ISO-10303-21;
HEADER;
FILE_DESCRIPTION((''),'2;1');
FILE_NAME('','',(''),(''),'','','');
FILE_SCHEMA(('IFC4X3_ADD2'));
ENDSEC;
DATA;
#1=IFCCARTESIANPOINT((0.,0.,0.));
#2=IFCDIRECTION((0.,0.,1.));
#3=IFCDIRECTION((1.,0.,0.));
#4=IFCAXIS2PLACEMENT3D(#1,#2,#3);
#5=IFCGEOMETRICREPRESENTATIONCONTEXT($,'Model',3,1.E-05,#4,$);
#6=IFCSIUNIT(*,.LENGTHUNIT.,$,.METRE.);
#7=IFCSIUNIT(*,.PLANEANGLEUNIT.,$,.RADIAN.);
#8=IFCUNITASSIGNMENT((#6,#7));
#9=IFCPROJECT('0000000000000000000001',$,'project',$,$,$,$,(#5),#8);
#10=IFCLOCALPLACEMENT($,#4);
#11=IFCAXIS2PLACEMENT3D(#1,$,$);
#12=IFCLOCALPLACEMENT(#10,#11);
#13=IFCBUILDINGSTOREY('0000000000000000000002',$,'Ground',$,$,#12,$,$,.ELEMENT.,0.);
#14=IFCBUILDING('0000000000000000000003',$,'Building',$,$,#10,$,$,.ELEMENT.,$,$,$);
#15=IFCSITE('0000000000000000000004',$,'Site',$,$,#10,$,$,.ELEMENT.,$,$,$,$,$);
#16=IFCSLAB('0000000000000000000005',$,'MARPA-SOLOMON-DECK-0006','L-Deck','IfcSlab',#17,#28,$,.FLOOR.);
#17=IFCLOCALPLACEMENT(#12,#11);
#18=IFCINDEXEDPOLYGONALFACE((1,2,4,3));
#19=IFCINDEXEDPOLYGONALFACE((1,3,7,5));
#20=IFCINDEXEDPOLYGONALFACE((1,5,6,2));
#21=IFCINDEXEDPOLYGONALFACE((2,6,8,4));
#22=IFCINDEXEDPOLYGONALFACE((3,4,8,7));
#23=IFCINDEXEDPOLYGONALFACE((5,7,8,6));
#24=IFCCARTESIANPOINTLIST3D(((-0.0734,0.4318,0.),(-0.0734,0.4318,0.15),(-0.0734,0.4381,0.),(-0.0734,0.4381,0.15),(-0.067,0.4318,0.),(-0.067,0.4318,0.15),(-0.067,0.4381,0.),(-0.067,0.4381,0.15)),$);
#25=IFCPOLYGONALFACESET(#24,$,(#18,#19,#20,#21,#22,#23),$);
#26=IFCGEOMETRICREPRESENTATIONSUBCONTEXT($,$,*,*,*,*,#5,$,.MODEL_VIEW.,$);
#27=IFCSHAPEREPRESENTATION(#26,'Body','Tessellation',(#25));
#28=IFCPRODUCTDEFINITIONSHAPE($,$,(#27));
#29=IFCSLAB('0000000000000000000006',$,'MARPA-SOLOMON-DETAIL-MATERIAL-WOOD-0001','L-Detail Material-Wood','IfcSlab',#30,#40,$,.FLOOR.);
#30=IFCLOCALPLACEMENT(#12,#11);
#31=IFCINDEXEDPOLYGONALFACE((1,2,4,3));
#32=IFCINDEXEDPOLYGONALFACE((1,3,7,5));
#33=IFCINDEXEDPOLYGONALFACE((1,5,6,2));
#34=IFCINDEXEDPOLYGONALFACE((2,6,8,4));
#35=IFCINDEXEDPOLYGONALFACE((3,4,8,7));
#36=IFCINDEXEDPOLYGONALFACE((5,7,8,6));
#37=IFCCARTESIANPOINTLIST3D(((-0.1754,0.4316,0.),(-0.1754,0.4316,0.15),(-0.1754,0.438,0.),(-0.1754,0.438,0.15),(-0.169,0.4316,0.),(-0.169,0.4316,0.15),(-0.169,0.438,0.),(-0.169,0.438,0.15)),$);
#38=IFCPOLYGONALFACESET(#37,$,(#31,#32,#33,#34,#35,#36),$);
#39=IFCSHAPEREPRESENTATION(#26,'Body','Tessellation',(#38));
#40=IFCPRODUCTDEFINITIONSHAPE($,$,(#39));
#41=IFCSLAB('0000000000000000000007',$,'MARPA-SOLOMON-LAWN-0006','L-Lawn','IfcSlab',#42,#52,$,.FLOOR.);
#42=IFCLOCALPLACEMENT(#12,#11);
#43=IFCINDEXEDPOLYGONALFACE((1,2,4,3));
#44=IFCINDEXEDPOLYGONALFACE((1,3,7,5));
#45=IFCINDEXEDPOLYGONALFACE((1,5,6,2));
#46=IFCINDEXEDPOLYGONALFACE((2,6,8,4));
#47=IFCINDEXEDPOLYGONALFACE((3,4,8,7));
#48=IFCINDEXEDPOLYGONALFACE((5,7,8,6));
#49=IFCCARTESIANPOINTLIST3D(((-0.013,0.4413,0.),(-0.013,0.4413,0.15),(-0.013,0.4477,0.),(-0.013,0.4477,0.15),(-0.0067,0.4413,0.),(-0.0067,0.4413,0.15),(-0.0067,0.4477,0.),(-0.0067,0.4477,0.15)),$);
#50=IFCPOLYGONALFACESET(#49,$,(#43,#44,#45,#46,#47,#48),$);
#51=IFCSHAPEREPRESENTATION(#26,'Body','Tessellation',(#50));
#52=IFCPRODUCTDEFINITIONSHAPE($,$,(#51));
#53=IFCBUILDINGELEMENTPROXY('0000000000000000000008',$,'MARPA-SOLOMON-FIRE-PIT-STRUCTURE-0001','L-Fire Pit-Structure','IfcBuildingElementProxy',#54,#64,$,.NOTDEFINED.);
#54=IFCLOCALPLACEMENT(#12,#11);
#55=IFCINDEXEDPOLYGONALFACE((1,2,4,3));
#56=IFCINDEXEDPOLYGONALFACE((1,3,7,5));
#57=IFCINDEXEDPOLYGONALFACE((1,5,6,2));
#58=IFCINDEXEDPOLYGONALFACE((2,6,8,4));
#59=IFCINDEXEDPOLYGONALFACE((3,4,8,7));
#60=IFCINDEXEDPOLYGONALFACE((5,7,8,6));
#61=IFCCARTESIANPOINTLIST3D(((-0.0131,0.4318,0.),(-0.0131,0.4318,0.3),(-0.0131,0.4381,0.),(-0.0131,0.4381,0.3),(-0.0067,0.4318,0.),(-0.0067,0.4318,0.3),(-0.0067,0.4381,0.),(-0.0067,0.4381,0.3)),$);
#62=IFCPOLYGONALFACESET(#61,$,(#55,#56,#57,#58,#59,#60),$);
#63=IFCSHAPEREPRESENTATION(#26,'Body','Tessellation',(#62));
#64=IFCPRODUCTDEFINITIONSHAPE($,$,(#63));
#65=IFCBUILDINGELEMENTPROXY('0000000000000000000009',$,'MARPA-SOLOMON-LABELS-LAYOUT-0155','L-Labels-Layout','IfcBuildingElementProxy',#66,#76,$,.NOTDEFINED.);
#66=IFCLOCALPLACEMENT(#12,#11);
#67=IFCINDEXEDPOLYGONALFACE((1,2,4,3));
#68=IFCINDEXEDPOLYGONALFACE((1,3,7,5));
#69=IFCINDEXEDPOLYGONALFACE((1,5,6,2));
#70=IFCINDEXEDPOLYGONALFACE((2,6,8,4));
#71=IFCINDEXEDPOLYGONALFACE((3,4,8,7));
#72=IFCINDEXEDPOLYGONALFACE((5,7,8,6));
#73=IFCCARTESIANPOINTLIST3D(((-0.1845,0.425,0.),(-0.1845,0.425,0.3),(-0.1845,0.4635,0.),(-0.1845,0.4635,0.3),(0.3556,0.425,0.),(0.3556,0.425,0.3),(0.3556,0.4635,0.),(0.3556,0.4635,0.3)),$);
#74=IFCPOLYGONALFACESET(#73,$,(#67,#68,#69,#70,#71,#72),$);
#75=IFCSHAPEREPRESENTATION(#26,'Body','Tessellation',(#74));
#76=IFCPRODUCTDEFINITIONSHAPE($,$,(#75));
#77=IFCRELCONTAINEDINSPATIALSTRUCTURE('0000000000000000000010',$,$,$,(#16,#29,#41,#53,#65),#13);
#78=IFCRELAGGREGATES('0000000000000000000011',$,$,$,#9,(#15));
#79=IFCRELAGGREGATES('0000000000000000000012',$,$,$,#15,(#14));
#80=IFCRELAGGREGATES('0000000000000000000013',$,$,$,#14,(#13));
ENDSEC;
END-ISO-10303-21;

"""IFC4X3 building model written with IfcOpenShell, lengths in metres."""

from ifc_helpers import new_model, si_unit, frame, origin, origin_with_axes, place, context, subcontext, project, spatial, polyline, outline, extrude, element, save


model = new_model("IFC4X3")

# Units and contexts
model_context = context("Model", 3, precision=1e-05, world=origin_with_axes())
sub_context = subcontext(model_context, None, None, "MODEL_VIEW")
ifc_project = project(units=[si_unit("LENGTHUNIT", "METRE"), si_unit("PLANEANGLEUNIT", "RADIAN")], contexts=[model_context])

# Site, building, storey
placement = place(None, origin_with_axes())
site = spatial("IfcSite", under=ifc_project, at=placement, Name="Site", CompositionType="ELEMENT")
building = spatial("IfcBuilding", under=site, at=placement, Name="Building", CompositionType="ELEMENT")
storey_placement = place(placement, origin())
storey = spatial("IfcBuildingStorey", under=building, at=storey_placement, Name="Ground", CompositionType="ELEMENT", Elevation=0.0)

# Slabs
for number, where, name, description in (
    (1, (-0.0734, 0.4318, 0.0), "MARPA-SOLOMON-DECK-0006", "L-Deck"),
    (2, (-0.1754, 0.4316, 0.0), "MARPA-SOLOMON-DETAIL-MATERIAL-WOOD-0001", "L-Detail Material-Wood"),
):
    element("IfcSlab", number, at=place(storey_placement, frame(where)), inside=storey, Name=name, Description=description, ObjectType="IfcSlab", PredefinedType="FLOOR", context=sub_context, shape_type="SweptSolid", body=[
        extrude(outline(polyline([(0.0, 0.0064), (0.0063, 0.0064), (0.0063, 0.0), (0.0, 0.0), (0.0, 0.0064)])), origin(), (0.0, 0.0, 1.0), 0.15),
    ])
for number, where, name in (
    (3, (-0.013, 0.4413, 0.0), "MARPA-SOLOMON-LAWN-0006"),
):
    element("IfcSlab", number, at=place(storey_placement, frame(where)), inside=storey, Name=name, Description="L-Lawn", ObjectType="IfcSlab", PredefinedType="FLOOR", context=sub_context, shape_type="SweptSolid", body=[
        extrude(outline(polyline([(0.0, 0.0064), (0.0063, 0.0064), (0.0063, 0.0), (0.0, 0.0), (0.0, 0.0064)])), origin(), (0.0, 0.0, 1.0), 0.15),
    ])

# Building element proxies
for number, where, name in (
    (4, (-0.0131, 0.4318, 0.0), "MARPA-SOLOMON-FIRE-PIT-STRUCTURE-0001"),
):
    element("IfcBuildingElementProxy", number, at=place(placement, frame(where)), inside=storey, Name=name, Description="L-Fire Pit-Structure", ObjectType="IfcBuildingElementProxy", PredefinedType="NOTDEFINED", context=sub_context, shape_type="SweptSolid", body=[
        extrude(outline(polyline([(0.0, 0.0064), (0.0063, 0.0064), (0.0063, 0.0), (0.0, 0.0), (0.0, 0.0064)])), origin(), (0.0, 0.0, 1.0), 0.3),
    ])
for number, where, name in (
    (5, (-0.1845, 0.425, 0.0), "MARPA-SOLOMON-LABELS-LAYOUT-0155"),
):
    element("IfcBuildingElementProxy", number, at=place(placement, frame(where)), inside=storey, Name=name, Description="L-Labels-Layout", ObjectType="IfcBuildingElementProxy", PredefinedType="NOTDEFINED", context=sub_context, shape_type="SweptSolid", body=[
        extrude(outline(polyline([(0.0, 0.0385), (0.5401, 0.0385), (0.5401, 0.0), (0.0, 0.0), (0.0, 0.0385)])), origin(), (0.0, 0.0, 1.0), 0.3),
    ])

save(model, "model.ifc")
